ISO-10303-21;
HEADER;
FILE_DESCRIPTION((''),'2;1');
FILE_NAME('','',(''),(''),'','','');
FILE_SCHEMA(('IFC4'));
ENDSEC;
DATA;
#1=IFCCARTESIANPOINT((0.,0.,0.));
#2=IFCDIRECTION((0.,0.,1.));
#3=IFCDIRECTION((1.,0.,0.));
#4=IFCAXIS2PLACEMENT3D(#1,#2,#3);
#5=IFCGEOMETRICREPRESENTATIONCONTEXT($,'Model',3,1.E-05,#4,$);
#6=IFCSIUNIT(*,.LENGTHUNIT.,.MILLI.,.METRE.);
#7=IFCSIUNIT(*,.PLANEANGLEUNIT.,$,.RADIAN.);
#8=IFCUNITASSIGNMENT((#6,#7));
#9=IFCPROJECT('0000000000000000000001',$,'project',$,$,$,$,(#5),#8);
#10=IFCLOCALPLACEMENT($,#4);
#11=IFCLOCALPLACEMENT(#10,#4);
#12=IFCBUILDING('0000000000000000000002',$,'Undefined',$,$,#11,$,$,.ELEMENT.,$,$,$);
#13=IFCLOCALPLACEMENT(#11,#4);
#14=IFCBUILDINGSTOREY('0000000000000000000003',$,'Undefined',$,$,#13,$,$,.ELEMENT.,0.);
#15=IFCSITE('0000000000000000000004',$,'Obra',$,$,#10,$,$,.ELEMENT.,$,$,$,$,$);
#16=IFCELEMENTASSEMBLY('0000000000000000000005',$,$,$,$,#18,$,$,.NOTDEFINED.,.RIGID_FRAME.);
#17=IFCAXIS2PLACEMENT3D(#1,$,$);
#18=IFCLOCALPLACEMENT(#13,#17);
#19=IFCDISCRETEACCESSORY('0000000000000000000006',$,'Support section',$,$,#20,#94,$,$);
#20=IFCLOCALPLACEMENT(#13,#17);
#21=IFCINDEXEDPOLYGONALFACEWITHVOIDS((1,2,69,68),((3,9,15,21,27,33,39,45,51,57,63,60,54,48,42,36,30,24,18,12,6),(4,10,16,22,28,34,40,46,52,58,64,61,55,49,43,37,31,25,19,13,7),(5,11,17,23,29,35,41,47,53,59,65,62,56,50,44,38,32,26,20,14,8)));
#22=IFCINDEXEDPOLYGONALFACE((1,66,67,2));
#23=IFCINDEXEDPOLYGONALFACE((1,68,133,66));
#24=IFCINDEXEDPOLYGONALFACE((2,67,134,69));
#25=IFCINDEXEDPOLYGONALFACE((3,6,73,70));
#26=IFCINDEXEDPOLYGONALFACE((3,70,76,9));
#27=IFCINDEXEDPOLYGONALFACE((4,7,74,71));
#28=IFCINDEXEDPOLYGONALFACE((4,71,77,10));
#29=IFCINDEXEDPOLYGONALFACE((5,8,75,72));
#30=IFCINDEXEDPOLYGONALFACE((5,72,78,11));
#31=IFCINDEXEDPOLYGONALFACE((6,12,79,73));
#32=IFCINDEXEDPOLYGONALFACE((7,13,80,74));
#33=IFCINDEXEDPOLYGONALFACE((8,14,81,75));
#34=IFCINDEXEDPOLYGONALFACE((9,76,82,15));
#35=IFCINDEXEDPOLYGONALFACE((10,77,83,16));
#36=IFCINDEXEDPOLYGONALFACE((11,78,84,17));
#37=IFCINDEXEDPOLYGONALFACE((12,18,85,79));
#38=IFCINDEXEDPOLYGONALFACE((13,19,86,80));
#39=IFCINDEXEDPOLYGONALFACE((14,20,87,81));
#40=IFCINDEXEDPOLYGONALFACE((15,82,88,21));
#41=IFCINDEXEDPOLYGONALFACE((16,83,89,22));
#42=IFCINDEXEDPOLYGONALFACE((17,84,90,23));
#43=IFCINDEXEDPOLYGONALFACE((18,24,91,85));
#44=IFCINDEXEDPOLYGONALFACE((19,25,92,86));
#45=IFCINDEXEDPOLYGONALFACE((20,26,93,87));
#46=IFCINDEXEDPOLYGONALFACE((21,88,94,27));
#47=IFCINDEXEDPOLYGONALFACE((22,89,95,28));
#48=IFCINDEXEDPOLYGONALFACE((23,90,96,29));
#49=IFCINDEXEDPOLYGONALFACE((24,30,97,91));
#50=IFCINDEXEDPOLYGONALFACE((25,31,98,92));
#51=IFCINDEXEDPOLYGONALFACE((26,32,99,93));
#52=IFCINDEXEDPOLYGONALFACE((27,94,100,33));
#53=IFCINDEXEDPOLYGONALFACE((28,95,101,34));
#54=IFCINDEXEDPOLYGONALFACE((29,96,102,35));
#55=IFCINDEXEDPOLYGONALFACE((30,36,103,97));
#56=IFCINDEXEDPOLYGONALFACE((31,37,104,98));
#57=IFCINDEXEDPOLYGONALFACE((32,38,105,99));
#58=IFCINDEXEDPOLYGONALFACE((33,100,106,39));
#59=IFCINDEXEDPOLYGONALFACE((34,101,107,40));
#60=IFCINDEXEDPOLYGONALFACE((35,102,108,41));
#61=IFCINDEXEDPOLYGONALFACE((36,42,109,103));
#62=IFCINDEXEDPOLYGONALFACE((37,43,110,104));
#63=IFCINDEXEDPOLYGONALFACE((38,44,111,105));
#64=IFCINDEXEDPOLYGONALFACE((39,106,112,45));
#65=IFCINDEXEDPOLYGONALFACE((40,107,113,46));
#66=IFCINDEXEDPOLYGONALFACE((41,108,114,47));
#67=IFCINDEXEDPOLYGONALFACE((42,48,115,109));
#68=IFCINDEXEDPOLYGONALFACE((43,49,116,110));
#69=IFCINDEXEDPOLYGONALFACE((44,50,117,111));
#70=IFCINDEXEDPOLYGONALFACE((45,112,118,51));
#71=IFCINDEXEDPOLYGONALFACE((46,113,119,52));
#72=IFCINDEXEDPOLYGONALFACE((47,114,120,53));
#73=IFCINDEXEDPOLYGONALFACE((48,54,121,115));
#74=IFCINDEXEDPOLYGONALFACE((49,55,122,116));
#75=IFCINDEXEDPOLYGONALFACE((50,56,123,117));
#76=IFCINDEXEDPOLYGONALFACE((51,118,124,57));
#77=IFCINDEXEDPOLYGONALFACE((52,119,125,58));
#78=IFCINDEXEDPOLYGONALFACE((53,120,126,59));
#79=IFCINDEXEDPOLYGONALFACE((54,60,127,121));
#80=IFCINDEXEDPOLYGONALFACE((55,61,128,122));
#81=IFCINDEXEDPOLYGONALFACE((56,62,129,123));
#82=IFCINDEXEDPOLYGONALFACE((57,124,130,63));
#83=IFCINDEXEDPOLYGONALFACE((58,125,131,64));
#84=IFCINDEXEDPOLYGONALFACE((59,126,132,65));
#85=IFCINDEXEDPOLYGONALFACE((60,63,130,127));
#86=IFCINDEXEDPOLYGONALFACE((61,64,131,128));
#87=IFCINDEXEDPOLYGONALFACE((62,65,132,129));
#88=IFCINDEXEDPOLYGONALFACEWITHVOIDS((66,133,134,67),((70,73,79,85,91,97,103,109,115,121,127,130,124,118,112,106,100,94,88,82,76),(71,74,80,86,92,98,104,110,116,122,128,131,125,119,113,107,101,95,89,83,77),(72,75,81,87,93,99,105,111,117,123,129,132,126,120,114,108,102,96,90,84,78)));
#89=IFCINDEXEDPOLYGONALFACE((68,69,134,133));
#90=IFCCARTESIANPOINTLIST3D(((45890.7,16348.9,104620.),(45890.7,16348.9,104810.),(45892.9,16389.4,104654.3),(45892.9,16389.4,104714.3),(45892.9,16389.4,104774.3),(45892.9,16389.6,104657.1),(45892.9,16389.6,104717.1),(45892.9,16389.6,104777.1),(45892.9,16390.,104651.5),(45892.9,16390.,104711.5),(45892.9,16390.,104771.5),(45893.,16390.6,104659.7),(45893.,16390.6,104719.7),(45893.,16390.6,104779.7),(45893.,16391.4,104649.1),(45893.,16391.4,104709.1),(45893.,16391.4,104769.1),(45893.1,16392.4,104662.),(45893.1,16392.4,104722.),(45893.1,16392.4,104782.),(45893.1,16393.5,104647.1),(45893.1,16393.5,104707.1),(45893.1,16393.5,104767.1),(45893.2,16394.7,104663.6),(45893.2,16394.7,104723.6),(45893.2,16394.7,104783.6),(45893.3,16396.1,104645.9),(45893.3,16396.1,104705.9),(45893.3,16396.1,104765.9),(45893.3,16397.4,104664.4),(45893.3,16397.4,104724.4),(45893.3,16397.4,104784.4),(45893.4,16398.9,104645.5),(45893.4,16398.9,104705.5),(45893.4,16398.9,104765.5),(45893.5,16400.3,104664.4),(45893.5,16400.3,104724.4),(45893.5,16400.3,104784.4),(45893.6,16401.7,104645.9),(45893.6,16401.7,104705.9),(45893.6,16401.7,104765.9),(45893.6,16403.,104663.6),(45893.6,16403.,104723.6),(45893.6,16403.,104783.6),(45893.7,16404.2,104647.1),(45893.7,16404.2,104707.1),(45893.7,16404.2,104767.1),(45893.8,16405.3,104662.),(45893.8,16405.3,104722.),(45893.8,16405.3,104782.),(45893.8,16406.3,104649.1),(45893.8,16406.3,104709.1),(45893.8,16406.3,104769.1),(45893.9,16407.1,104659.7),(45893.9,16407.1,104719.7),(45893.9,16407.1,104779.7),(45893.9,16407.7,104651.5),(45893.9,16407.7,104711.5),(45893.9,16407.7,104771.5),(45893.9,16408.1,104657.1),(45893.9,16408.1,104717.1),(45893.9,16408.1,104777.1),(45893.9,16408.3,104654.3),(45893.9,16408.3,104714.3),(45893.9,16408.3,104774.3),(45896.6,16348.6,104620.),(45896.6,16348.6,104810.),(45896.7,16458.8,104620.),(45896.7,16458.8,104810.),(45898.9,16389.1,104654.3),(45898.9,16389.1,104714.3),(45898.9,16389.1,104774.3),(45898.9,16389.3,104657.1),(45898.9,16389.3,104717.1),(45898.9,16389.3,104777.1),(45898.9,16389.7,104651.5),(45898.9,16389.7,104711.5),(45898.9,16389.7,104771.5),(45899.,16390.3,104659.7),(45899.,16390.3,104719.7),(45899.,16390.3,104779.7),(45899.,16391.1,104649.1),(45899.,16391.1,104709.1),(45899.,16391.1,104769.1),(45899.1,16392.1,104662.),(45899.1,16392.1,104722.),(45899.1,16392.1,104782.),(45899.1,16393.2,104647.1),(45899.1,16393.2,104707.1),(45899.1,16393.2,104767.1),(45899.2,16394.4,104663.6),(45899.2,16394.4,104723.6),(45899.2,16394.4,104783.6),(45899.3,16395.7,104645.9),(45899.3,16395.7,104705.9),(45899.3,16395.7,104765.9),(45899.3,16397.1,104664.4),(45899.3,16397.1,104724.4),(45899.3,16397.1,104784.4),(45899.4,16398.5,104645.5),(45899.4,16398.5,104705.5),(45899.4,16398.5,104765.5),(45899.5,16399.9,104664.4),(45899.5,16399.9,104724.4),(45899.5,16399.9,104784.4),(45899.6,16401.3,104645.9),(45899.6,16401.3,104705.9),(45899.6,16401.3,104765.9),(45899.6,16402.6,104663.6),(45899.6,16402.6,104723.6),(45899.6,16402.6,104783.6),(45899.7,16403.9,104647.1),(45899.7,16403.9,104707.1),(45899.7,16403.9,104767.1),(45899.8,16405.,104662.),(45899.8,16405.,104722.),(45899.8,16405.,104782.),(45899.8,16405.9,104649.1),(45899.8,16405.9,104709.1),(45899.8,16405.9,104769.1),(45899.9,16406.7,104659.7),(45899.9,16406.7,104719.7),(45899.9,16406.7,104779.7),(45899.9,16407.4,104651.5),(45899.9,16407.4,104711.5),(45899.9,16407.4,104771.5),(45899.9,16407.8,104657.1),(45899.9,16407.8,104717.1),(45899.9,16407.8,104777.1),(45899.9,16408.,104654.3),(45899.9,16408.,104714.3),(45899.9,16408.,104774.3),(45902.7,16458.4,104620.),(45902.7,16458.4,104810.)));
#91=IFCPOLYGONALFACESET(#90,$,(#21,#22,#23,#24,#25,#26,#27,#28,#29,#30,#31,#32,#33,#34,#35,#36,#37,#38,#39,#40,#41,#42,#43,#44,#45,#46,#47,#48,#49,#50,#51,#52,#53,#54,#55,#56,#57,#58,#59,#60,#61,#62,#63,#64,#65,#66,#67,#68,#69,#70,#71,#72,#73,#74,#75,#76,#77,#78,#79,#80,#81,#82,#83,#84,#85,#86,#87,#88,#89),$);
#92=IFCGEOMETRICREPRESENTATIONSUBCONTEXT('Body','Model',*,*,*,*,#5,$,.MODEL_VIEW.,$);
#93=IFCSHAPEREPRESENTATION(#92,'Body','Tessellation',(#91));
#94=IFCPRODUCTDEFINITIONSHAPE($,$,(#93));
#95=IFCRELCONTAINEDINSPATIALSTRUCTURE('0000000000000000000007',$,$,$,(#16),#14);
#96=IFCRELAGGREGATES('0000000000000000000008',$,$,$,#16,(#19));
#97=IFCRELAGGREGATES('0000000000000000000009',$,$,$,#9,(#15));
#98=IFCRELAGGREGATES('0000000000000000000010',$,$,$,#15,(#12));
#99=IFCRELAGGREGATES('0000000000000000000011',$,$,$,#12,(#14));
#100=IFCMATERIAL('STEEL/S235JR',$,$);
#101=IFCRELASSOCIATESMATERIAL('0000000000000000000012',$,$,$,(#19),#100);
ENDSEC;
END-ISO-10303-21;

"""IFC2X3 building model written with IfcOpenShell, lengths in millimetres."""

from ifc_helpers import new_model, si_unit, frame, origin_with_axes, origin_2d_with_axis, place, context, subcontext, project, spatial, rectangle, circle, extrude, source, transform, mapped, material, element, aggregate, save


model = new_model("IFC2X3")

# Units and contexts
model_context = context("Model", 3, precision=1e-05, world=origin_with_axes())
body_context = subcontext(model_context, "Body", "Model", "MODEL_VIEW")
ifc_project = project(units=[si_unit("LENGTHUNIT", "METRE", prefix="MILLI"), si_unit("PLANEANGLEUNIT", "RADIAN")], contexts=[model_context])

# Site, building, storey
site_placement = place(None, origin_with_axes())
site = spatial("IfcSite", under=ifc_project, at=site_placement, Name="Obra", CompositionType="ELEMENT")
building_placement = place(site_placement, origin_with_axes())
building = spatial("IfcBuilding", under=site, at=building_placement, Name="Undefined", CompositionType="ELEMENT")
storey_placement = place(building_placement, origin_with_axes())
storey = spatial("IfcBuildingStorey", under=building, at=storey_placement, Name="Undefined", CompositionType="ELEMENT", Elevation=0.0)

# Shared definitions
ifc_material = material(Name="STEEL/S235JR")

# Shared definitions
shared_shape_1 = source(origin_with_axes(), body_context, "Body", "SweptSolid", [
    extrude(circle(Radius=9.5, at=origin_2d_with_axis()), frame((0.0, -9.2, 0.0), z_axis=(0.0, 1.0, 0.0), x_axis=(1.0, 0.0, 0.0)), (0.0, 0.0, 1.0), 6.2),
])

# Element assembly, discrete accessory, opening
assembly_1_placement = place(storey_placement, origin_with_axes())
assembly_1 = element("IfcElementAssembly", 1, at=assembly_1_placement, inside=storey, AssemblyPlace="NOTDEFINED", PredefinedType="RIGID_FRAME")
discrete_accessory_1_placement = place(assembly_1_placement, frame((45896.7, 16403.7, 104620.0), z_axis=(0.0, 0.0, 1.0), x_axis=(0.055268, 0.998472, 0.0)))
discrete_accessory_1 = element("IfcDiscreteAccessory", 2, at=discrete_accessory_1_placement, material=ifc_material, Name="Support section", context=body_context, shape_type="SweptSolid", body=[
    extrude(rectangle(XDim=6.0, YDim=110.0, at=origin_2d_with_axis()), frame((0.0, 0.0, 190.0), z_axis=(0.0, 0.0, -1.0), x_axis=(0.0, 1.0, 0.0)), (0.0, 0.0, 1.0), 190.0),
])
opening_1_placement = place(assembly_1_placement, frame((45905.3, 16448.3, 104835.0), z_axis=(-0.055268, -0.998472, 0.0), x_axis=(0.0, 0.0, -1.0)))
element("IfcOpeningElement", 3, at=opening_1_placement, cuts=discrete_accessory_1, ObjectType="Opening", context=body_context, shape_type="MappedRepresentation", body=[
    mapped(shared_shape_1, transform((60.0, 0.0, 50.0))),
    mapped(shared_shape_1, transform((120.0, 0.0, 50.0))),
    mapped(shared_shape_1, transform((180.0, 0.0, 50.0))),
])
aggregate(assembly_1, [discrete_accessory_1])

save(model, "model.ifc")
